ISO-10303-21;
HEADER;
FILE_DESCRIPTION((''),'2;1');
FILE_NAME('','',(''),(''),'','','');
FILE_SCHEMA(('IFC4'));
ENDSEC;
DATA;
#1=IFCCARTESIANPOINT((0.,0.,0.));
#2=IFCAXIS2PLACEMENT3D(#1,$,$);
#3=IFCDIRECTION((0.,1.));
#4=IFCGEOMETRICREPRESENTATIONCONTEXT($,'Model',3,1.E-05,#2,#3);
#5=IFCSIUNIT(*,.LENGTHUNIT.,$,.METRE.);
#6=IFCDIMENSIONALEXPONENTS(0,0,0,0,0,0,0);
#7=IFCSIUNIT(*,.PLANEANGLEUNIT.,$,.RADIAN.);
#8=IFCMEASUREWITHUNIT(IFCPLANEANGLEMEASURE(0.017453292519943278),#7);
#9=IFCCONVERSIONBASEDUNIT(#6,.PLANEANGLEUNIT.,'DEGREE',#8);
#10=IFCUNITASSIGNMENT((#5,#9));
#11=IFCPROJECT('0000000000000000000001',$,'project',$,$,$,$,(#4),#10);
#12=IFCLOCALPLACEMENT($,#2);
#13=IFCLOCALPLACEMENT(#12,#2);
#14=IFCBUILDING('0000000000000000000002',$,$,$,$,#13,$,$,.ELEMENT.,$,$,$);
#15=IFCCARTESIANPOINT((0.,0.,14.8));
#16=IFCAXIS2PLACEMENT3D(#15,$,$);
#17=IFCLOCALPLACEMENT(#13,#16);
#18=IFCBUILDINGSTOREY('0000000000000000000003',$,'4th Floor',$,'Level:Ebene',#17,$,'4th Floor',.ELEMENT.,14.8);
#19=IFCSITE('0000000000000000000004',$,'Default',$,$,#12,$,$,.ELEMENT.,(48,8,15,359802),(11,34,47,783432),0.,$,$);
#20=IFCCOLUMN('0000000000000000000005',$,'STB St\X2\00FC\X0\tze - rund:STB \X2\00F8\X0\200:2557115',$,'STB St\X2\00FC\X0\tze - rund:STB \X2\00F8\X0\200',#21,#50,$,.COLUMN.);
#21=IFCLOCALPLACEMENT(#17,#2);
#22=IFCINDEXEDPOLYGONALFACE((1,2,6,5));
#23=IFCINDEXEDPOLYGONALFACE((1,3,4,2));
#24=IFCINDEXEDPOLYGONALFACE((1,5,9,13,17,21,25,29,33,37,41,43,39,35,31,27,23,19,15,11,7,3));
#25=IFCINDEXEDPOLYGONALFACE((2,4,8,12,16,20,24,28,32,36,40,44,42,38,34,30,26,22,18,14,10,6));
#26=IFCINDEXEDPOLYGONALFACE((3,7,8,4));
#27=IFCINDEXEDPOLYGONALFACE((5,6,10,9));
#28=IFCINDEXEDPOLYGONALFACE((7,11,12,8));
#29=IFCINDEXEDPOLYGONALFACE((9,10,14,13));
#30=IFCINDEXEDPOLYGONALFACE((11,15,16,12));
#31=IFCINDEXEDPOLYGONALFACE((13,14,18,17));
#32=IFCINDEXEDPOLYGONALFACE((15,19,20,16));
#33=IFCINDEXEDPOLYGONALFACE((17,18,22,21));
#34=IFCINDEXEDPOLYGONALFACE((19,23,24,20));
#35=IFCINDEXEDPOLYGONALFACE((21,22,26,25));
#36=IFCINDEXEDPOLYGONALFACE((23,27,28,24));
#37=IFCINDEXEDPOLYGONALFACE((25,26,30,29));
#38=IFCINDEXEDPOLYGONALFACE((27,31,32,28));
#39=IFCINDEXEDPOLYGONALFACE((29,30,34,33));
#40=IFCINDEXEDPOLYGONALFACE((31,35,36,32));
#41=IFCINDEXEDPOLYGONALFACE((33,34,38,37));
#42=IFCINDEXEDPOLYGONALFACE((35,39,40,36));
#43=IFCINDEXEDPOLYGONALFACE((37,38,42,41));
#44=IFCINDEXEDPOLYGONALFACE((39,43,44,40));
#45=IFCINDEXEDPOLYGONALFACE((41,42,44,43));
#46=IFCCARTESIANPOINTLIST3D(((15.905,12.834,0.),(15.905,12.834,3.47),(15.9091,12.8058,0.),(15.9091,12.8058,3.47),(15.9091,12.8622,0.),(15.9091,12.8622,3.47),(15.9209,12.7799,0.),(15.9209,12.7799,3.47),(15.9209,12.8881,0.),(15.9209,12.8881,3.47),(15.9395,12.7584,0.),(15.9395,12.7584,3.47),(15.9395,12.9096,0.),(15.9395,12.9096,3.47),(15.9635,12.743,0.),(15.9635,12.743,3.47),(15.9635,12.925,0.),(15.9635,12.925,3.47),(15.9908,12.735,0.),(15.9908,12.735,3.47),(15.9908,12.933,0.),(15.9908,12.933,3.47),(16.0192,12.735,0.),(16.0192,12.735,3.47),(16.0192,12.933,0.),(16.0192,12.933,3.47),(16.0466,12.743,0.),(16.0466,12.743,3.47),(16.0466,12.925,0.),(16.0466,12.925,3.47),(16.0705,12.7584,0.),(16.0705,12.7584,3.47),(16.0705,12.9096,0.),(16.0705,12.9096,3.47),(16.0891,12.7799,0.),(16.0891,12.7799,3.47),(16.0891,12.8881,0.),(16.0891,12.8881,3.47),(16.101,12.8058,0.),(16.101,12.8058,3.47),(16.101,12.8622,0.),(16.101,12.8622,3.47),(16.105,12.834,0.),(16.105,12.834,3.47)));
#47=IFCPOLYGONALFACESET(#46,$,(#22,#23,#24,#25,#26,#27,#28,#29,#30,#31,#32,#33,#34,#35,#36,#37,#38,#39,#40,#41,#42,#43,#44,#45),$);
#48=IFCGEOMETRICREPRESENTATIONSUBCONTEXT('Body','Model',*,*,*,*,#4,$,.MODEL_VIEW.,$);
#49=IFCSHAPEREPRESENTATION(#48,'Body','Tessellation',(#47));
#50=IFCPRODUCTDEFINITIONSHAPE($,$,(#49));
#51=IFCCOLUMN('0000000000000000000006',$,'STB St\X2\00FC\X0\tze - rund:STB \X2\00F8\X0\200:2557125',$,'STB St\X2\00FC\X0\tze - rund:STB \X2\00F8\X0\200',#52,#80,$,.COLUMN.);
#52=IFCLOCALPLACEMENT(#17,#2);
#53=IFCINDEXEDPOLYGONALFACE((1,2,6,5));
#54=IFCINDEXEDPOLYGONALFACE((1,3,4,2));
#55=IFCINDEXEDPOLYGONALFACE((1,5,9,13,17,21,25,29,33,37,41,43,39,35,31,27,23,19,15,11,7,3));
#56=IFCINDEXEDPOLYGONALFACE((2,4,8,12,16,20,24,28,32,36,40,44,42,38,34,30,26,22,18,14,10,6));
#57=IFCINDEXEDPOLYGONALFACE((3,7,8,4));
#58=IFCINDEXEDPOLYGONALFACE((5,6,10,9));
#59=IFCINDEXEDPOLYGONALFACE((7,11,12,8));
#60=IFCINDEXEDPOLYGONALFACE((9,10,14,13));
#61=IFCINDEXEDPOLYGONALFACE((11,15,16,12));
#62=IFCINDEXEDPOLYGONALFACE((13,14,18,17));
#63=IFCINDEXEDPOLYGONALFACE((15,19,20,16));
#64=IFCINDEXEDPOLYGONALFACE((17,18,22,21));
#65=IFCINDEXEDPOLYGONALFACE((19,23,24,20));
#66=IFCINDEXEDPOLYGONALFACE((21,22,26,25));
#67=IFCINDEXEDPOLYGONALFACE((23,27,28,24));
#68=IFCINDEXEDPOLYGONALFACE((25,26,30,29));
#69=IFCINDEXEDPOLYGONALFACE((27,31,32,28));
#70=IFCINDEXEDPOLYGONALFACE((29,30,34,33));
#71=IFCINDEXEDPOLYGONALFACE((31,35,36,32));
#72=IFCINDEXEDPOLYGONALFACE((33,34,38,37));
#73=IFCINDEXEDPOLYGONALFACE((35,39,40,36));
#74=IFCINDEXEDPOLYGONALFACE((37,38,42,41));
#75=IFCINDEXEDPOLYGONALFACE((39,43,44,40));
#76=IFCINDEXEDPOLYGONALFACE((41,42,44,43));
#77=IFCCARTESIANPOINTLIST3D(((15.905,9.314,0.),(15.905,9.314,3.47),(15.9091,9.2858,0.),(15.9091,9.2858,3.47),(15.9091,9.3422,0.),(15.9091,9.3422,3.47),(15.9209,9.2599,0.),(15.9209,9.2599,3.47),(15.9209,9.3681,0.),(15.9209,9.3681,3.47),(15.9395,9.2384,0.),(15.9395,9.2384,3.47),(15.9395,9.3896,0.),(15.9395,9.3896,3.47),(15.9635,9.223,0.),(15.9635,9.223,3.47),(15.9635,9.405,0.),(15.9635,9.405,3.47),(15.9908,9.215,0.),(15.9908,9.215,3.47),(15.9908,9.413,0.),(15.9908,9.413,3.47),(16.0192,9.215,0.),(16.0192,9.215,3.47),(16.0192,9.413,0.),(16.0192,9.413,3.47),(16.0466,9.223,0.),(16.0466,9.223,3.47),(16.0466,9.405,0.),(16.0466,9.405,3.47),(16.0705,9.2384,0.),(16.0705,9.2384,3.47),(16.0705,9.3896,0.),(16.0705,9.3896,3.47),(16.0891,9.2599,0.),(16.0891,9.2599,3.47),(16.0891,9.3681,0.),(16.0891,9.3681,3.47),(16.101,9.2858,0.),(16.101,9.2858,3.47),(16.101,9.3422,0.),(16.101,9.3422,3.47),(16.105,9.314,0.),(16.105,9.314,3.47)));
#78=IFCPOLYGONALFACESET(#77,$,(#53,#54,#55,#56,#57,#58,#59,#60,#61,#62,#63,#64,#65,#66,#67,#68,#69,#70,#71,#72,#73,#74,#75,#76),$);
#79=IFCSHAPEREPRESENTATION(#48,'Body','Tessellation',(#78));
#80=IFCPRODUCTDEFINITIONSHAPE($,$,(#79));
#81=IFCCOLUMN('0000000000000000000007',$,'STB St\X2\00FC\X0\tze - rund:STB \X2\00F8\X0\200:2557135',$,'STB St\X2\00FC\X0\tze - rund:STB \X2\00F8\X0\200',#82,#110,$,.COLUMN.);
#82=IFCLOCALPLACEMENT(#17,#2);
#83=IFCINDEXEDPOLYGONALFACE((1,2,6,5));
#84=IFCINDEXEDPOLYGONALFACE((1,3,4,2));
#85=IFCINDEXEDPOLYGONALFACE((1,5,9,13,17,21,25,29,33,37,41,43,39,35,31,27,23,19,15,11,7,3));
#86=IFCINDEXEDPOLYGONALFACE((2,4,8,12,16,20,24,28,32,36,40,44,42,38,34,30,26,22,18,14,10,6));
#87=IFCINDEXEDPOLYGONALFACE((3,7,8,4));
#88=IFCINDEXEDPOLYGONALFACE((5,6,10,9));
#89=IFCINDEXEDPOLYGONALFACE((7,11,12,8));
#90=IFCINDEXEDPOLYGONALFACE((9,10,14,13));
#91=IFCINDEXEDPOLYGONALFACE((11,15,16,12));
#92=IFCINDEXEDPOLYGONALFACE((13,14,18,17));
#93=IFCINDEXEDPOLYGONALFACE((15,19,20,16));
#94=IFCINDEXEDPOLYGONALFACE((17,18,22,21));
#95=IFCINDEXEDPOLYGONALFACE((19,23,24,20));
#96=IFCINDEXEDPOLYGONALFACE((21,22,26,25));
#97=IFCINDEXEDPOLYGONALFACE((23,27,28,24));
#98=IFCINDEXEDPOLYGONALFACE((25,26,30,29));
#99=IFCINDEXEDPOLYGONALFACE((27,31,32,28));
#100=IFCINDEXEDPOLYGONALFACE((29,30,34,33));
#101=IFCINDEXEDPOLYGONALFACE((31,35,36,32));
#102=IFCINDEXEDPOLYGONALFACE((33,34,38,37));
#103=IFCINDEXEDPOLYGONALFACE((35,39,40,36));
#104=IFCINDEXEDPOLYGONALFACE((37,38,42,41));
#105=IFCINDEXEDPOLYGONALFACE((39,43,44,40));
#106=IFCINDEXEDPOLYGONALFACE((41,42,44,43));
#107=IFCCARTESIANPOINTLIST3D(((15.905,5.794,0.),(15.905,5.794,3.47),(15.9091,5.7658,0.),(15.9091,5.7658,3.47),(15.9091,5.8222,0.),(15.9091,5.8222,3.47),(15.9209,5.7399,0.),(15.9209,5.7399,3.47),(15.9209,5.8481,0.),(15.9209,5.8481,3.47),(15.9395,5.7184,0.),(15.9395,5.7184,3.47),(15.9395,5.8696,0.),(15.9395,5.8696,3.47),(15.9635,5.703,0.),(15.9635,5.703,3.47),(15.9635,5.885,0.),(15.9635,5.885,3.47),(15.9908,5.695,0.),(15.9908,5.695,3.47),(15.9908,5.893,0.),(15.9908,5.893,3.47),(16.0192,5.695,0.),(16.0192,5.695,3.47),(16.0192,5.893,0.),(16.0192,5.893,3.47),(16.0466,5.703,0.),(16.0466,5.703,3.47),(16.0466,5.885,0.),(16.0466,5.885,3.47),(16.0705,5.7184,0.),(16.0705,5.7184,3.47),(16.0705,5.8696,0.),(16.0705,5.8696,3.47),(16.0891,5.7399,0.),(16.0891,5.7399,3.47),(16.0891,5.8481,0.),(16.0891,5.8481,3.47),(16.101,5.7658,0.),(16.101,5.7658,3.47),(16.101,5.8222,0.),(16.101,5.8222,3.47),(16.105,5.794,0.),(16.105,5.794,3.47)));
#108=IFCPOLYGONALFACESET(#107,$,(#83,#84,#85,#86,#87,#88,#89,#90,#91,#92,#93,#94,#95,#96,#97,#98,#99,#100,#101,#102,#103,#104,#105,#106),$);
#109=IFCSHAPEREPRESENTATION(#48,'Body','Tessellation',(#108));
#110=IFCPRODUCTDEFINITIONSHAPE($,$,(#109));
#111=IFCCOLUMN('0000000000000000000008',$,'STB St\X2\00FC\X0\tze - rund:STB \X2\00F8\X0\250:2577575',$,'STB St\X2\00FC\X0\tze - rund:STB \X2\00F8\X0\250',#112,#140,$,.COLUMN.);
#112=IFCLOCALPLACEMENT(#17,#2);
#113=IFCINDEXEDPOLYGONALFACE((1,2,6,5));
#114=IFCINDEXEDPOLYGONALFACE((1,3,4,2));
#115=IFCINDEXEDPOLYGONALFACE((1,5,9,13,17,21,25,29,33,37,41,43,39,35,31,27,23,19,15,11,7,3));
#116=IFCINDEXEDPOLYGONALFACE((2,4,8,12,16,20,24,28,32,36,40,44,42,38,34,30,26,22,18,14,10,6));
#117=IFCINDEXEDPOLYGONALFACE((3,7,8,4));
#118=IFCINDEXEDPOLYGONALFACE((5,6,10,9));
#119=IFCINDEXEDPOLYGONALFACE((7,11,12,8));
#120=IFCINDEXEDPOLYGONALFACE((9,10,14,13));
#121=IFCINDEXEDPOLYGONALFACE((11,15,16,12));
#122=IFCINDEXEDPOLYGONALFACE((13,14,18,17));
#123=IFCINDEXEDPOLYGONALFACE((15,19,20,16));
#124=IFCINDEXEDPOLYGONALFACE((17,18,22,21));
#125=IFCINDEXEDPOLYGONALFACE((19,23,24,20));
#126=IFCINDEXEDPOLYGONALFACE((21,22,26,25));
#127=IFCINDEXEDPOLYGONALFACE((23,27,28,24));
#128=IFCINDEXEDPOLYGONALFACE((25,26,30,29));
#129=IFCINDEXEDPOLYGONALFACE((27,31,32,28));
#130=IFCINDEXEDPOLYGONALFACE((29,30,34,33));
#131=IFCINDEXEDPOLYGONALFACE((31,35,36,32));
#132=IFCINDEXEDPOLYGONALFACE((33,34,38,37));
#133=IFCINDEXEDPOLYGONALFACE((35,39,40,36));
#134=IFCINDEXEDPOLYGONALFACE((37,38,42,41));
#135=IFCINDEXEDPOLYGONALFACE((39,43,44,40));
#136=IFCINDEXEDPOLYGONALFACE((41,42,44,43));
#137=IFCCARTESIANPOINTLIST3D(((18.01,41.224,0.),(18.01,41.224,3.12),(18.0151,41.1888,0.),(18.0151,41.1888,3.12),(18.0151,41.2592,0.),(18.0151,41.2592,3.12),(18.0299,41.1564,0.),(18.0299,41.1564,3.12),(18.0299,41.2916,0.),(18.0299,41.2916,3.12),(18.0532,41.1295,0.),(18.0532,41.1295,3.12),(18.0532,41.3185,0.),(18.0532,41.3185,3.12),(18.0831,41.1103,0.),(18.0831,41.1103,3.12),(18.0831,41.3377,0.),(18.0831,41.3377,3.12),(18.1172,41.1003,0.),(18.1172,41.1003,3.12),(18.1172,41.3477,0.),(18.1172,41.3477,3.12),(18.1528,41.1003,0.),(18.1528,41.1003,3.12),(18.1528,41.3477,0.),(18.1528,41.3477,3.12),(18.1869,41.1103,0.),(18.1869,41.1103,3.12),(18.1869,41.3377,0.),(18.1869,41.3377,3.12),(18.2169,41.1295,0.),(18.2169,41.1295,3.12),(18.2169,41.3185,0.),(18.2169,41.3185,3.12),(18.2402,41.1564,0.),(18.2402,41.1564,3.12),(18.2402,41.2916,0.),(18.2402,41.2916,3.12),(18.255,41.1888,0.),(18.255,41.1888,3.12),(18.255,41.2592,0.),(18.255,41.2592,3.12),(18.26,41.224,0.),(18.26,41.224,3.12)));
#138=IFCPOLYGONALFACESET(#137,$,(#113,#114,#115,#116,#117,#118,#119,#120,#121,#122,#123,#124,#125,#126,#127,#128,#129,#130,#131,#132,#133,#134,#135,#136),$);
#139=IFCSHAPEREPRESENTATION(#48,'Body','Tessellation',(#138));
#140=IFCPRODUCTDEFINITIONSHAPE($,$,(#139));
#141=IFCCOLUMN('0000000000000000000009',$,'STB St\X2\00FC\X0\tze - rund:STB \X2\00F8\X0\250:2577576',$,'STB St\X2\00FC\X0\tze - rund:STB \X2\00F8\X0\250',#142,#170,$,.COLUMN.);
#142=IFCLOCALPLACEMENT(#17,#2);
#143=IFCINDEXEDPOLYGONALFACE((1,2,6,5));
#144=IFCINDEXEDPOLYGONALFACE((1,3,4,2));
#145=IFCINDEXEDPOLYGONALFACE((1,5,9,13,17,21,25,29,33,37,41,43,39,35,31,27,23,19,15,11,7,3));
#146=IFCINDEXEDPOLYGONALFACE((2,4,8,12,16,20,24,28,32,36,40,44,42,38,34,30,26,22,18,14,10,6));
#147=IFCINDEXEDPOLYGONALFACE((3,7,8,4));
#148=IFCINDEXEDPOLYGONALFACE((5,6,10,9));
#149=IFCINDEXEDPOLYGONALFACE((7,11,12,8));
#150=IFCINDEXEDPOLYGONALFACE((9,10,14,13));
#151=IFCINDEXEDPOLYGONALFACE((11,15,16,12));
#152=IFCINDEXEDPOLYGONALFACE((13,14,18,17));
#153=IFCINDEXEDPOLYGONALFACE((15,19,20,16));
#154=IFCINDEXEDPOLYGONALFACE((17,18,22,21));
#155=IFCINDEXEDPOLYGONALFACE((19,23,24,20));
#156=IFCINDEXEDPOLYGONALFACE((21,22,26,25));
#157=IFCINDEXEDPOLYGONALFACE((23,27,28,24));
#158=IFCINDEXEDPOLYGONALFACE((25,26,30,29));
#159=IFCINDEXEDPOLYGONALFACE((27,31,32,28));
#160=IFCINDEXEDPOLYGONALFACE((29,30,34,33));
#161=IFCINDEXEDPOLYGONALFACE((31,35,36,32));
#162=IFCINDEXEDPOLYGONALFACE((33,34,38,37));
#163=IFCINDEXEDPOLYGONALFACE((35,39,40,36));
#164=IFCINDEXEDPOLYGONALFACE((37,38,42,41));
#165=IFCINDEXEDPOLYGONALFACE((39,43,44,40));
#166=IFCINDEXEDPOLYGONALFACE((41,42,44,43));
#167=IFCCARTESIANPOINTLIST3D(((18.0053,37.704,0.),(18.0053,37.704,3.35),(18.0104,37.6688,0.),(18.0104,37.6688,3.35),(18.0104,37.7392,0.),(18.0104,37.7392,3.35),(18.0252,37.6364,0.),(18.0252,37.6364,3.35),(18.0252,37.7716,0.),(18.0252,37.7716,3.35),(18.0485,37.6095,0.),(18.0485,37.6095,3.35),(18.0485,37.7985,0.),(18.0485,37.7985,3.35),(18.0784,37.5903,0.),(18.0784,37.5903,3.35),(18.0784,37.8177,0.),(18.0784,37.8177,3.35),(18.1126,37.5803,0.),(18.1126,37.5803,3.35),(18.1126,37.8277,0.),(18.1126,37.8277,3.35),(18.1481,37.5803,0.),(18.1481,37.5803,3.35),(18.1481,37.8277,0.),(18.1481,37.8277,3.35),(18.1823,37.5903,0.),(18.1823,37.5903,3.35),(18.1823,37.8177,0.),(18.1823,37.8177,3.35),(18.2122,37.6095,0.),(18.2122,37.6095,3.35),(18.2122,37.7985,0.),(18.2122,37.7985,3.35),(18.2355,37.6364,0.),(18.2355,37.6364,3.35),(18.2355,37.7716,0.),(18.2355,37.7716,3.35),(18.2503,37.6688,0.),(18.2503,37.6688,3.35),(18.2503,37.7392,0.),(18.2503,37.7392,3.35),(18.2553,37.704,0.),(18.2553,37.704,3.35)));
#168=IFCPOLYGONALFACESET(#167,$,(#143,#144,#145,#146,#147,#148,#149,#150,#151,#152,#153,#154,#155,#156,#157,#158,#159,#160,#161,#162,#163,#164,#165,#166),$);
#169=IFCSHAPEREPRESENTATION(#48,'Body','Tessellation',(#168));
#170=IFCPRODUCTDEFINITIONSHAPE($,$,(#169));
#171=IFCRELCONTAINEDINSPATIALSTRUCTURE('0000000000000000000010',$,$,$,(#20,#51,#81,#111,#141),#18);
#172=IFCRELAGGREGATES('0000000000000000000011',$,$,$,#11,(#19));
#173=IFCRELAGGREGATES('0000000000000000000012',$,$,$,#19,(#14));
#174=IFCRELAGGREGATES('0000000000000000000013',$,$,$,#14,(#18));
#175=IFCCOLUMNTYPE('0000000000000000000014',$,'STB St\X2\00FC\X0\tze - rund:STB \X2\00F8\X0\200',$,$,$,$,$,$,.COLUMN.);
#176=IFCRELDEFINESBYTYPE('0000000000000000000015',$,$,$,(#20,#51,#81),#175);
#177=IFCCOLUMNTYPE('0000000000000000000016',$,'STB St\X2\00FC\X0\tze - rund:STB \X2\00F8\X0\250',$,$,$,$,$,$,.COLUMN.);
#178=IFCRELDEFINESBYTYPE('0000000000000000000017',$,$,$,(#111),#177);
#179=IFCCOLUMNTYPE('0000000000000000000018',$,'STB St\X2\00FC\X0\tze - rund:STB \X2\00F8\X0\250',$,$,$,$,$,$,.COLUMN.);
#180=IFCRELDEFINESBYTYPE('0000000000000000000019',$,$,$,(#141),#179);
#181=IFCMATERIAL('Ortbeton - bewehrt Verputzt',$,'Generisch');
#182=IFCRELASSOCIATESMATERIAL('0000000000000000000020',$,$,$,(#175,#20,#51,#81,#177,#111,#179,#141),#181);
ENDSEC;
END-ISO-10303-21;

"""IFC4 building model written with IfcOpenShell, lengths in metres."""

from ifc_helpers import new_model, entity, si_unit, converted_unit, direction, frame, origin, place, context, subcontext, project, spatial, arc, indexed_curve, outline, extrude, source, transform, mapped, material, type_object, type_shapes, element, save


model = new_model("IFC4")

# Units and contexts
model_context = context("Model", 3, precision=1e-05, world=origin(), true_north=direction((0.0, 1.0)))
body_context = subcontext(model_context, "Body", "Model", "MODEL_VIEW")
ifc_project = project(units=[si_unit("LENGTHUNIT", "METRE"), converted_unit("PLANEANGLEUNIT", "DEGREE", entity("IfcPlaneAngleMeasure", 0.017453292519943278), si_unit("PLANEANGLEUNIT", "RADIAN"), dimensions=[0, 0, 0, 0, 0, 0, 0])], contexts=[model_context])

# Site, building, storey
site_placement = place(None, origin())
site = spatial("IfcSite", under=ifc_project, at=site_placement, Name="Default", CompositionType="ELEMENT", RefLatitude=(48, 8, 15, 359802), RefLongitude=(11, 34, 47, 783432), RefElevation=0.0)
building_placement = place(site_placement, origin())
building = spatial("IfcBuilding", under=site, at=building_placement, CompositionType="ELEMENT")
storey_placement = place(building_placement, frame((0.0, 0.0, 14.8)))
storey = spatial("IfcBuildingStorey", under=building, at=storey_placement, Name="4th Floor", ObjectType="Level:Ebene", LongName="4th Floor", CompositionType="ELEMENT", Elevation=14.8)

# Columns
ifc_material_1 = material(Name="Ortbeton - bewehrt Verputzt", Category="Generisch")
column_type_1 = type_object("IfcColumnType", Name="STB Stütze - rund:STB ø200", PredefinedType="COLUMN", material=ifc_material_1)
shared_shape_1 = source(origin(), body_context, "Body", "SweptSolid", [
    extrude(outline(indexed_curve([(-0.1, 0.0), (0.0, -0.1), (0.1, 0.0), (0.0, 0.1)], segments=[arc(1, 2, 3), arc(3, 4, 1)], self_intersect=False)), frame((0.0, 0.0, 14.8)), (0.0, 0.0, 1.0), 3.47),
])
type_shapes(column_type_1, [shared_shape_1])
for number, where, name in (
    (1, (16.005, 12.834, -14.8), "STB Stütze - rund:STB ø200:2557115"),
    (2, (16.005, 9.314, -14.8), "STB Stütze - rund:STB ø200:2557125"),
    (3, (16.005, 5.794, -14.8), "STB Stütze - rund:STB ø200:2557135"),
):
    element("IfcColumn", number, at=place(storey_placement, frame(where)), inside=storey, type_object=column_type_1, material=ifc_material_1, Name=name, ObjectType="STB Stütze - rund:STB ø200", PredefinedType="COLUMN", context=body_context, shape_type="MappedRepresentation", body=[
        mapped(shared_shape_1, transform((0.0, 0.0, 0.0), scale=1.0)),
    ])
column_type_2 = type_object("IfcColumnType", Name="STB Stütze - rund:STB ø250", PredefinedType="COLUMN", material=ifc_material_1)
shared_shape_2 = source(origin(), body_context, "Body", "SweptSolid", [
    extrude(outline(indexed_curve([(-0.125, 0.0), (0.0, -0.125), (0.125, 0.0), (0.0, 0.125)], segments=[arc(1, 2, 3), arc(3, 4, 1)], self_intersect=False)), frame((18.135, 41.224, 14.8)), (0.0, 0.0, 1.0), 3.12),
])
type_shapes(column_type_2, [shared_shape_2])
column_1_placement = place(storey_placement, frame((0.0, 0.0, -14.8)))
element("IfcColumn", 4, at=column_1_placement, inside=storey, type_object=column_type_2, material=ifc_material_1, Name="STB Stütze - rund:STB ø250:2577575", ObjectType="STB Stütze - rund:STB ø250", PredefinedType="COLUMN", context=body_context, shape_type="MappedRepresentation", body=[
    mapped(shared_shape_2, transform((0.0, 0.0, 0.0), scale=1.0)),
])
column_type_3 = type_object("IfcColumnType", Name="STB Stütze - rund:STB ø250", PredefinedType="COLUMN", material=ifc_material_1)
shared_shape_3 = source(origin(), body_context, "Body", "SweptSolid", [
    extrude(outline(indexed_curve([(-0.125, 0.0), (0.0, -0.125), (0.125, 0.0), (0.0, 0.125)], segments=[arc(1, 2, 3), arc(3, 4, 1)], self_intersect=False)), frame((18.1303, 37.704, 14.8)), (0.0, 0.0, 1.0), 3.35),
])
type_shapes(column_type_3, [shared_shape_3])
column_2_placement = place(storey_placement, frame((0.0, 0.0, -14.8)))
element("IfcColumn", 5, at=column_2_placement, inside=storey, type_object=column_type_3, material=ifc_material_1, Name="STB Stütze - rund:STB ø250:2577576", ObjectType="STB Stütze - rund:STB ø250", PredefinedType="COLUMN", context=body_context, shape_type="MappedRepresentation", body=[
    mapped(shared_shape_3, transform((0.0, 0.0, 0.0), scale=1.0)),
])

save(model, "model.ifc")
